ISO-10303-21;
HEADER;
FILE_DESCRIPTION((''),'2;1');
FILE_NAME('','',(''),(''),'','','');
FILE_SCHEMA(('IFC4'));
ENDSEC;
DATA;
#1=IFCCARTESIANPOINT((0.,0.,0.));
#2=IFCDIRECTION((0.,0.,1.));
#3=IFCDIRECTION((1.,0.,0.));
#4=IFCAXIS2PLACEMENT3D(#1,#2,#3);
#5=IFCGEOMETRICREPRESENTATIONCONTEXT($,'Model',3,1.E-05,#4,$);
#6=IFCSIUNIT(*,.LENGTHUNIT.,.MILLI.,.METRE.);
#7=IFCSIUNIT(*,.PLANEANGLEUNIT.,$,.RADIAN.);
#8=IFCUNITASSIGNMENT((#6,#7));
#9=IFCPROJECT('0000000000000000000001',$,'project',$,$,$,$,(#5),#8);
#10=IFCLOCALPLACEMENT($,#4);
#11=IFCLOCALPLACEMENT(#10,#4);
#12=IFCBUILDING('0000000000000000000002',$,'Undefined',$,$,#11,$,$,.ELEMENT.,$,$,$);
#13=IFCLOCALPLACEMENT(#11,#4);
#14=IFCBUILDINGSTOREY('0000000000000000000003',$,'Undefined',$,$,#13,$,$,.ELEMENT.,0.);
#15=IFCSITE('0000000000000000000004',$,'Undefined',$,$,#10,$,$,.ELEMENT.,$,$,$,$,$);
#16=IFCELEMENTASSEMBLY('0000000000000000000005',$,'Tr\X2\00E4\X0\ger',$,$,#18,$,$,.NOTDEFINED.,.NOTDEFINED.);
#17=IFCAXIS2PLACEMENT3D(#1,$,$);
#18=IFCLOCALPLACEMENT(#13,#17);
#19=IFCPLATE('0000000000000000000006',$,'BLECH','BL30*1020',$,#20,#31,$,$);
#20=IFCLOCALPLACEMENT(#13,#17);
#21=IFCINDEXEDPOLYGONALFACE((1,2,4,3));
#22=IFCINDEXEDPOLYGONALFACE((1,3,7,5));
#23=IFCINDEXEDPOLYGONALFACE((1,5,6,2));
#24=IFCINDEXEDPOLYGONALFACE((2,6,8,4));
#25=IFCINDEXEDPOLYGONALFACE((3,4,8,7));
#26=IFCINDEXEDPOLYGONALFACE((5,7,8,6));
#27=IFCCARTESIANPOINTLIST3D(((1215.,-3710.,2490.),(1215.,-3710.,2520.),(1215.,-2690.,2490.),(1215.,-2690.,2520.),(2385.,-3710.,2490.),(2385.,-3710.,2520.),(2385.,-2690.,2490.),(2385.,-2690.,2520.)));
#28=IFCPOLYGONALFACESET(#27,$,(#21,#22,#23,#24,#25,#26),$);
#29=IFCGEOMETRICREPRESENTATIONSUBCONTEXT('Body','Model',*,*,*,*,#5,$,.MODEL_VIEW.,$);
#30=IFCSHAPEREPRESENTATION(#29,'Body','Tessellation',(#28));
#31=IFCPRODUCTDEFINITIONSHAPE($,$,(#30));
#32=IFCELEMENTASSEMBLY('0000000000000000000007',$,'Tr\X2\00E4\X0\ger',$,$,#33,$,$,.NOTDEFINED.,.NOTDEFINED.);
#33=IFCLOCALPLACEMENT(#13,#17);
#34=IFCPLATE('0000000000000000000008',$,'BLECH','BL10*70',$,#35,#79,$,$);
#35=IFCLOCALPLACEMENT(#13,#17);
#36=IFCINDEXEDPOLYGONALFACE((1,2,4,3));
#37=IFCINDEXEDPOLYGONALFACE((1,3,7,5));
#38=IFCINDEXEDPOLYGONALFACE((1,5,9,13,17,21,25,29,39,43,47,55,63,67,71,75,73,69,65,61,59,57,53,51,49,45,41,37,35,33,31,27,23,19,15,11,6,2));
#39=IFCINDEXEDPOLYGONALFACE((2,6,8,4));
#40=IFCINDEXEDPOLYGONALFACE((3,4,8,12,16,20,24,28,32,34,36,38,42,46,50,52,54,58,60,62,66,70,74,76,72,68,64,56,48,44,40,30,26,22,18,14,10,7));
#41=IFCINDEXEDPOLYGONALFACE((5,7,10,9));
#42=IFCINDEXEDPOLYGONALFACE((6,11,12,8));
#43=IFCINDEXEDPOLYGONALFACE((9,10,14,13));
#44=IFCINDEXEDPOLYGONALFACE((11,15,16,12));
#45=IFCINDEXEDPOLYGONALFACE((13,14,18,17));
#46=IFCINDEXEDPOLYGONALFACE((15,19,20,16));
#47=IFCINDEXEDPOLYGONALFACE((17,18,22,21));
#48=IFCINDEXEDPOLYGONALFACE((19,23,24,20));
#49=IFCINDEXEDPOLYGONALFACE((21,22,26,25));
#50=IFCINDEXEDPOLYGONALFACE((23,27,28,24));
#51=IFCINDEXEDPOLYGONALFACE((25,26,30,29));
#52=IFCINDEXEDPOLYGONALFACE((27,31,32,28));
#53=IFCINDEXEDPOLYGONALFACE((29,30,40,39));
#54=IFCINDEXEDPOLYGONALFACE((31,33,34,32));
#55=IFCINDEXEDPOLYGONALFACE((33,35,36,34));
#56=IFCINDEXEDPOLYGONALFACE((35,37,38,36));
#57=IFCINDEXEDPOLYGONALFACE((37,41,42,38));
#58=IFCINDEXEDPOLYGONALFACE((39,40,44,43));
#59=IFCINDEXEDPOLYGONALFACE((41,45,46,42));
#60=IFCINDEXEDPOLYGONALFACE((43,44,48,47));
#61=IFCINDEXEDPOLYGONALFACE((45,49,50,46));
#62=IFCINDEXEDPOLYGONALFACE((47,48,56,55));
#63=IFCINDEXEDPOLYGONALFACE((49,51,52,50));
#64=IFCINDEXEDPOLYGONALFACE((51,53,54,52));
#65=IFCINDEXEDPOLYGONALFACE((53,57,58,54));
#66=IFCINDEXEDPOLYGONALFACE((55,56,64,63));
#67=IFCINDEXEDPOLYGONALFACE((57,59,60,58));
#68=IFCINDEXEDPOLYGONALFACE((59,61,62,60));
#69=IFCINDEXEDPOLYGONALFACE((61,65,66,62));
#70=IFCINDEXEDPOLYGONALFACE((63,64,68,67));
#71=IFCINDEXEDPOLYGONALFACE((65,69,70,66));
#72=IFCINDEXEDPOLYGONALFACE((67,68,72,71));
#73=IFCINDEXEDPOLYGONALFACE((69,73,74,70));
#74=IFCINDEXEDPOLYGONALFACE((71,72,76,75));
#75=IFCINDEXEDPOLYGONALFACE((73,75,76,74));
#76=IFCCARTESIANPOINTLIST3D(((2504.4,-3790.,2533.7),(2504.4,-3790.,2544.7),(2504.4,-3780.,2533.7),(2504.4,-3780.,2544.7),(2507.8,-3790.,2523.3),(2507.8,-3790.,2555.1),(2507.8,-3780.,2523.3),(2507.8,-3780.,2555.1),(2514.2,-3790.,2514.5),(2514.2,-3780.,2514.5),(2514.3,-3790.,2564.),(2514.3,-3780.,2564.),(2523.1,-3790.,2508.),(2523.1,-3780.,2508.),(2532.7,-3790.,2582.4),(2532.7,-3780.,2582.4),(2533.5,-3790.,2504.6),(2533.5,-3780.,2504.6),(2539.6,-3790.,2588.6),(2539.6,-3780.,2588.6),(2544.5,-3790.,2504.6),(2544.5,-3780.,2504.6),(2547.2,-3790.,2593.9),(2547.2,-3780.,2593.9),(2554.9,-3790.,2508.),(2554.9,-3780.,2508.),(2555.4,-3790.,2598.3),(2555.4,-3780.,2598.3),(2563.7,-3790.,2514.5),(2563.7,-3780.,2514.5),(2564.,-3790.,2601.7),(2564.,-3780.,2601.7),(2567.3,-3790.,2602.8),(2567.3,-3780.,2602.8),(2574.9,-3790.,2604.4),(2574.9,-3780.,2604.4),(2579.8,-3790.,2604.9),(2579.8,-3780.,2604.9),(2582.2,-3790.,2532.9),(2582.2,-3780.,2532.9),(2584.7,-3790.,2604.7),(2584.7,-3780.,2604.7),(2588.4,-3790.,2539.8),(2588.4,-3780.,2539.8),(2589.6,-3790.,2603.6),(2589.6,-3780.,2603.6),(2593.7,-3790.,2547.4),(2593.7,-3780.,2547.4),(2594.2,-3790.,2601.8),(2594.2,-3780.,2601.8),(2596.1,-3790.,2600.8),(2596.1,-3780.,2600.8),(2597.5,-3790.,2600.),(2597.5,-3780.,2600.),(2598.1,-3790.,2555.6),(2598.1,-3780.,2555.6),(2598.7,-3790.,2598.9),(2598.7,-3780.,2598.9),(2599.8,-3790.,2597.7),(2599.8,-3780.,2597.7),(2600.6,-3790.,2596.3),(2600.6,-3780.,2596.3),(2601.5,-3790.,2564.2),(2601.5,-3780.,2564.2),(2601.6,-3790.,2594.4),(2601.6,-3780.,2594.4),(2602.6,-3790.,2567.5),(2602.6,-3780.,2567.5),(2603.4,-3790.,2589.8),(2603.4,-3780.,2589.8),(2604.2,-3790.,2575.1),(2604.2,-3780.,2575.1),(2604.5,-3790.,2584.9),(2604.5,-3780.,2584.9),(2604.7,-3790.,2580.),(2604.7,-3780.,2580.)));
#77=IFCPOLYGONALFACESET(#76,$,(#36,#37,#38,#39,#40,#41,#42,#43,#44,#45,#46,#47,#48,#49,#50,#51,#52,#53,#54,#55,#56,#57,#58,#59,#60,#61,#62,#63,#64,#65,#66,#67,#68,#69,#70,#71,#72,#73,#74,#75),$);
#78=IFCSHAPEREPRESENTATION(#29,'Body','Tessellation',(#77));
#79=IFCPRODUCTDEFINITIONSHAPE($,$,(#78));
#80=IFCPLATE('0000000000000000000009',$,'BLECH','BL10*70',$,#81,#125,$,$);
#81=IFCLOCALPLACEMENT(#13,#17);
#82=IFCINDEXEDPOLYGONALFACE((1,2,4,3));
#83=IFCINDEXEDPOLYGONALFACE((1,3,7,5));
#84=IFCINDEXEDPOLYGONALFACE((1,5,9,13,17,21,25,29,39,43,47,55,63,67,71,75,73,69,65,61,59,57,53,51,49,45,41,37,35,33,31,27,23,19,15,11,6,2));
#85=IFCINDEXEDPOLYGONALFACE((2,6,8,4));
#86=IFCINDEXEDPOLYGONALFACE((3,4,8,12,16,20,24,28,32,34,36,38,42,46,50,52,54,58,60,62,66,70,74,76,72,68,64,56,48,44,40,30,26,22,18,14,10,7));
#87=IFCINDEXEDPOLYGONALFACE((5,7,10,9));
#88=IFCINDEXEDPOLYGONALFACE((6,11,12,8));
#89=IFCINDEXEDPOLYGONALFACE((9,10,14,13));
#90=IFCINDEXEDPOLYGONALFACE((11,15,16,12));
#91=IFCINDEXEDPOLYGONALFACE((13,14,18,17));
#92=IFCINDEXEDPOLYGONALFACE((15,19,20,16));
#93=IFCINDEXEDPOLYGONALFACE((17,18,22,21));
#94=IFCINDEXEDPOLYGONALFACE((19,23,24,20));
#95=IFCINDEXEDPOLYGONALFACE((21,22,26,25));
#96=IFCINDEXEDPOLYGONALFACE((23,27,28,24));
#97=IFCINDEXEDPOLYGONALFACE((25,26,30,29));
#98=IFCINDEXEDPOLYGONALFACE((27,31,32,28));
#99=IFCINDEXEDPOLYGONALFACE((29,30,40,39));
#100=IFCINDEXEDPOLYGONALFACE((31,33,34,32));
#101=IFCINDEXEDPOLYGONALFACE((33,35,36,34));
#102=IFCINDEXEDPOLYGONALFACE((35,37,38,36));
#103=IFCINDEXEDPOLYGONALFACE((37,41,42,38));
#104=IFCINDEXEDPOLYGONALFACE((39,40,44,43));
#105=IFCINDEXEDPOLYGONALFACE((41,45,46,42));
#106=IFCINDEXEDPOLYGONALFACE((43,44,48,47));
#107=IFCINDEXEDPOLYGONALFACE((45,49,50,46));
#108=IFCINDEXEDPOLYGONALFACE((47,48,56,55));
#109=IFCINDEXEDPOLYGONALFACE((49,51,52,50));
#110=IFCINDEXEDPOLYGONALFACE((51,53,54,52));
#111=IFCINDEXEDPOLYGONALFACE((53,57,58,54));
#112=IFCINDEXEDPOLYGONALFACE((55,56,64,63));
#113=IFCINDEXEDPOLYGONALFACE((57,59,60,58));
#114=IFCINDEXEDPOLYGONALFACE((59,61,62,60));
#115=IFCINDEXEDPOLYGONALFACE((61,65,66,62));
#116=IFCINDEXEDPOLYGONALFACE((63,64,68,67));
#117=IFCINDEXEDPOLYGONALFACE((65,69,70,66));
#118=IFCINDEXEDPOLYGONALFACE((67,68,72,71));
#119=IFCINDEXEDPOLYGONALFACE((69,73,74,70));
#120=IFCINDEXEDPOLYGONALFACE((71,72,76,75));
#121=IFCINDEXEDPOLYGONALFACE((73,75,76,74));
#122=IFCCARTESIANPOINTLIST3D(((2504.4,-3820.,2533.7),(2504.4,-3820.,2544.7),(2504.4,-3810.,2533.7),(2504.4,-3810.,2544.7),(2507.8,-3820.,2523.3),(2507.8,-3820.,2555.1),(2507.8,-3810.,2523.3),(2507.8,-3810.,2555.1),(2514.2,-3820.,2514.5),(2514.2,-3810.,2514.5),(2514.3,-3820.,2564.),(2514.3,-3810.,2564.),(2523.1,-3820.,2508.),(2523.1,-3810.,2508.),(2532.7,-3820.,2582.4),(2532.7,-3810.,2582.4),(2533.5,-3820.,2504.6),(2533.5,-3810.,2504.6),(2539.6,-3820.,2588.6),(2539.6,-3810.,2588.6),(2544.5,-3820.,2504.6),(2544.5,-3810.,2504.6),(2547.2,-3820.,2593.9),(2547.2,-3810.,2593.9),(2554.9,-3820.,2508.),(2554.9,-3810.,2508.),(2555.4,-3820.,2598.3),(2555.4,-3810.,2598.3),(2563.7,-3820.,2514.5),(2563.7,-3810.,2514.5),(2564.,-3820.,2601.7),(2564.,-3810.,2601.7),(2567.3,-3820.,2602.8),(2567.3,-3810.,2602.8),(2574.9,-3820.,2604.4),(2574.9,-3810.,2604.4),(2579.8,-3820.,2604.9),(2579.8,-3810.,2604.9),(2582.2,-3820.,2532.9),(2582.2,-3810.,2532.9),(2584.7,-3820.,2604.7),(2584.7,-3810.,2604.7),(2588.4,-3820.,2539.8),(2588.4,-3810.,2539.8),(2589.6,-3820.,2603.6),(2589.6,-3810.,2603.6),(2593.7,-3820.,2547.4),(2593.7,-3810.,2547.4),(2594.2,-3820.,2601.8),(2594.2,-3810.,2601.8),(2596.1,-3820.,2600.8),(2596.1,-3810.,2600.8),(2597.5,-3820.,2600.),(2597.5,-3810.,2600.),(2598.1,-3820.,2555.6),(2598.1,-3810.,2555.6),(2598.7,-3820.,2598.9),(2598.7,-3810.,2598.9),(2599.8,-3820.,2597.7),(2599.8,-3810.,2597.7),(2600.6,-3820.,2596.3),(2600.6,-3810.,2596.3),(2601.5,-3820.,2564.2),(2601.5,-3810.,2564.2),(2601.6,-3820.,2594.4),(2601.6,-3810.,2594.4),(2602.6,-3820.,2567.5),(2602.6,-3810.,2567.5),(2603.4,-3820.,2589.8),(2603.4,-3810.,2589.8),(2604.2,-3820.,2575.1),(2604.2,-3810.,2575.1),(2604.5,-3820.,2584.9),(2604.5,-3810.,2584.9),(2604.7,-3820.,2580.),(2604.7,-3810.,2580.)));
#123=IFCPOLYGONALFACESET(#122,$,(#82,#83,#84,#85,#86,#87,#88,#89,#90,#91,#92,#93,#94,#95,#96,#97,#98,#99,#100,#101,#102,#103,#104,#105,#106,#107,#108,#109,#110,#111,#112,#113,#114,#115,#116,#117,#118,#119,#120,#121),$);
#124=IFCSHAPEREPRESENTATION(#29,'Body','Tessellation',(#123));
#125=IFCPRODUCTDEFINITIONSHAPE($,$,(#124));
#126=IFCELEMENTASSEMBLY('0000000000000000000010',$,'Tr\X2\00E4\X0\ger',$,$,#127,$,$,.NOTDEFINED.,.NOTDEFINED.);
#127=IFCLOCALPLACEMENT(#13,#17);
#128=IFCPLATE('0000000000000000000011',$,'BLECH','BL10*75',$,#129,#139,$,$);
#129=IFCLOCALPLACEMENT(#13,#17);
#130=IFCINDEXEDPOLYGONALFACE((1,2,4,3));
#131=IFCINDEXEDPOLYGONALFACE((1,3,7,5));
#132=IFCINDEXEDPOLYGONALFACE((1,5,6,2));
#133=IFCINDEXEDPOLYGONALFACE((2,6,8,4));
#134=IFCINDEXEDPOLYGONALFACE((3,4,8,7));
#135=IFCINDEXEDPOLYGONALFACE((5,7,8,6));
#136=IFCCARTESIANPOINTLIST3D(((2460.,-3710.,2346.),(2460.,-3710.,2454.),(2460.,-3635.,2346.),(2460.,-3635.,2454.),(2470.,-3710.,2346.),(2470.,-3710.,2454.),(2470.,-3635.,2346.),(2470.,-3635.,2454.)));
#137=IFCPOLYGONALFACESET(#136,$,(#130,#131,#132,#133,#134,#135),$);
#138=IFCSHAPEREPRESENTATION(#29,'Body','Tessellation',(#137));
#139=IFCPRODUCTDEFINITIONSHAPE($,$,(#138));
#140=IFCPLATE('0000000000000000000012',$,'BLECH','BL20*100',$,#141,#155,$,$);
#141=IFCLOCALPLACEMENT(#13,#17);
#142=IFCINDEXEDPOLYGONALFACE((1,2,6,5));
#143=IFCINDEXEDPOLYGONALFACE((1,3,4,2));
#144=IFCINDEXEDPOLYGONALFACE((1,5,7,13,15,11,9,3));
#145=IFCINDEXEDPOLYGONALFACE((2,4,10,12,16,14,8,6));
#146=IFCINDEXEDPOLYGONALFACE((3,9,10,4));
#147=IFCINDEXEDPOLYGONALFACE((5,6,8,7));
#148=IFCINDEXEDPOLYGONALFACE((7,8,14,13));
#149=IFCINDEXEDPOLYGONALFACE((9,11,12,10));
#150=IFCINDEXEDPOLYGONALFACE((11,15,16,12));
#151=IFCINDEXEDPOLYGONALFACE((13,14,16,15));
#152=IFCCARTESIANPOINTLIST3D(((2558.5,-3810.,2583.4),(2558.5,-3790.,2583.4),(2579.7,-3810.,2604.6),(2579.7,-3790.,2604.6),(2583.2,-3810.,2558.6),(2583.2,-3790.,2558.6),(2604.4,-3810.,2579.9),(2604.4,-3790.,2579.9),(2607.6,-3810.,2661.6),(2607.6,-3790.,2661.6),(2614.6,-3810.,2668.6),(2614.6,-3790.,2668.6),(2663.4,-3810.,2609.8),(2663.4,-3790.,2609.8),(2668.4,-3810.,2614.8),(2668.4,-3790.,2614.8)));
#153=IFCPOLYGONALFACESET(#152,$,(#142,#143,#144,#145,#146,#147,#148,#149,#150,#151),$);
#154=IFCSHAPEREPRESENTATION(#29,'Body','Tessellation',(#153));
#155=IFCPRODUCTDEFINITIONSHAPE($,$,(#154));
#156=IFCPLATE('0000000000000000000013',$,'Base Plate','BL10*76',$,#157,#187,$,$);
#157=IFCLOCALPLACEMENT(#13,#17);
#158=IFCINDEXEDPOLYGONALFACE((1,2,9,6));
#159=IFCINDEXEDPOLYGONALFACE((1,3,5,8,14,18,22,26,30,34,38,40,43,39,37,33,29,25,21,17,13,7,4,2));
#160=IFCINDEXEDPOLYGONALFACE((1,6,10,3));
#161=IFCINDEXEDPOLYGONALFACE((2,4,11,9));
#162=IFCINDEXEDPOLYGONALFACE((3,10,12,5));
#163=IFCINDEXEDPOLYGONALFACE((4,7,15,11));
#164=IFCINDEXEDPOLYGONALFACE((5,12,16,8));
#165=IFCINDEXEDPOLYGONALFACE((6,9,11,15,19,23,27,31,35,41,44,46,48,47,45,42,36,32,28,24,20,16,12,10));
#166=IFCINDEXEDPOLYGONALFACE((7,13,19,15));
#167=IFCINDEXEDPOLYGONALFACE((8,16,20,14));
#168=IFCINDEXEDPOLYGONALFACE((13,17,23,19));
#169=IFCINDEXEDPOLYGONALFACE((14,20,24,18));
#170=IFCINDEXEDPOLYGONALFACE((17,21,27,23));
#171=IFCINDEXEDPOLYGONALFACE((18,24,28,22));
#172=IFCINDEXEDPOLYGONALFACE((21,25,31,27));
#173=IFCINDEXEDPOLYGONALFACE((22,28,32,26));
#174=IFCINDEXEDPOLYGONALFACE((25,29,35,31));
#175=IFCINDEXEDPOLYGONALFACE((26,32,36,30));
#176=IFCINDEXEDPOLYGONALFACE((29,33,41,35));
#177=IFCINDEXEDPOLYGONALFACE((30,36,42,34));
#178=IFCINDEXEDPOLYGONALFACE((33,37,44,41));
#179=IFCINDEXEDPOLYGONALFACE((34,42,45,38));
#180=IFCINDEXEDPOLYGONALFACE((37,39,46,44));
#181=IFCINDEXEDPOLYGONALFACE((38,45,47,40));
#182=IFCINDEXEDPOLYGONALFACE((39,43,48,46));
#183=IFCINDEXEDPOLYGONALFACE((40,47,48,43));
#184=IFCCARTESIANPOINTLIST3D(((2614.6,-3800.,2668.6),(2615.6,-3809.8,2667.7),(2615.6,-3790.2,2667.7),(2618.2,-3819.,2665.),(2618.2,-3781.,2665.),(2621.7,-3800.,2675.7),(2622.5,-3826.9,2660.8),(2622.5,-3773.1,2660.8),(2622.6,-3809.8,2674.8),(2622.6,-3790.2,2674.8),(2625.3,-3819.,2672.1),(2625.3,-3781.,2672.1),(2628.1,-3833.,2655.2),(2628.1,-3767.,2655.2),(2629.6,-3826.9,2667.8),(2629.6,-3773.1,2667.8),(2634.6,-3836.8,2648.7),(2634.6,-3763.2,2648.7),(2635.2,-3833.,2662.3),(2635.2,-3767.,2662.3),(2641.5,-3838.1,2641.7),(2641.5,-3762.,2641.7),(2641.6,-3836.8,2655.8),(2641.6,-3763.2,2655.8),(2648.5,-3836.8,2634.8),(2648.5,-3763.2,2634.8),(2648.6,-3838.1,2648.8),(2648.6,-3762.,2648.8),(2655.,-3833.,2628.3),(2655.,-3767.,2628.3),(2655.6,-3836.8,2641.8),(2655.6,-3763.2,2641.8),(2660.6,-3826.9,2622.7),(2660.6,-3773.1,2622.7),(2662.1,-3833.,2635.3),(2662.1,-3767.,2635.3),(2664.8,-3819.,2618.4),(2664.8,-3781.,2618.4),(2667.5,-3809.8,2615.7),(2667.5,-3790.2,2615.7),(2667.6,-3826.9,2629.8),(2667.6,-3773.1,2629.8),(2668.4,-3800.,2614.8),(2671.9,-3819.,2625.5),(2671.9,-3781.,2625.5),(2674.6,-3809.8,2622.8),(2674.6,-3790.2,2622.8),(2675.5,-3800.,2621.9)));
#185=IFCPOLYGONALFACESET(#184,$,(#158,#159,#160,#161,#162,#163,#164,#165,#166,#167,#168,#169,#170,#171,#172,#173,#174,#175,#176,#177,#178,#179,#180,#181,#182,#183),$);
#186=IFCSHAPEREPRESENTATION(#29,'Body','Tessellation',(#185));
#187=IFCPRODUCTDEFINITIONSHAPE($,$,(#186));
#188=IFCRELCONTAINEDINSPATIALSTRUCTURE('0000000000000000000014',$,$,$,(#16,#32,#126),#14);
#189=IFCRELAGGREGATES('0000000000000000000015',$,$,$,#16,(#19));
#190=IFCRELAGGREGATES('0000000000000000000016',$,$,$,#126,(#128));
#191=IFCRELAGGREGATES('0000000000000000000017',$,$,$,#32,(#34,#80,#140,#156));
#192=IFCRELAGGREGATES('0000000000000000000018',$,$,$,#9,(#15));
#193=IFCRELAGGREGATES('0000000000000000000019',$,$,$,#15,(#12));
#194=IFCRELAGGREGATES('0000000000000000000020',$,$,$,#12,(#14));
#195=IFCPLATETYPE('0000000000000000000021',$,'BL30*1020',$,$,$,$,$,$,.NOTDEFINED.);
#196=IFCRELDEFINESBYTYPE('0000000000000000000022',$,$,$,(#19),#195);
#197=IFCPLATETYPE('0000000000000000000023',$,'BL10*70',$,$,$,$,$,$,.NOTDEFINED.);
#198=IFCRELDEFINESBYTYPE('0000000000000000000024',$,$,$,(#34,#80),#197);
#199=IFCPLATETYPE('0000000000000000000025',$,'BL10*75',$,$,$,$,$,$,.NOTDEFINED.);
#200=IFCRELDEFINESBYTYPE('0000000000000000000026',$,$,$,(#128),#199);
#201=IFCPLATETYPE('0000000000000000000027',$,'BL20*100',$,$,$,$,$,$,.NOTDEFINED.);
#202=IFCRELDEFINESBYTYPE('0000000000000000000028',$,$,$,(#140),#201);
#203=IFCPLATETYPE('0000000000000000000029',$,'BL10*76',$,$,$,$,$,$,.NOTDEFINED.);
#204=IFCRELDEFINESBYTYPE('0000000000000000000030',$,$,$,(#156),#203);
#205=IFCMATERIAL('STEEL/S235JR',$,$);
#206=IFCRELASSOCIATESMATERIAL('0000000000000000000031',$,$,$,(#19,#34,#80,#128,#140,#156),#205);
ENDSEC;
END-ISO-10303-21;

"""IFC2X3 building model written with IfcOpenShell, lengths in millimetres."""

from ifc_helpers import new_model, si_unit, frame, frame_2d, origin_with_axes, place, context, subcontext, project, spatial, polyline, circle_curve, parameter, trimmed, segment, composite_curve, outline, extrude, material, type_object, element, aggregate, save


model = new_model("IFC2X3")

# Units and contexts
model_context = context("Model", 3, precision=1e-05, world=origin_with_axes())
body_context = subcontext(model_context, "Body", "Model", "MODEL_VIEW")
ifc_project = project(units=[si_unit("LENGTHUNIT", "METRE", prefix="MILLI"), si_unit("PLANEANGLEUNIT", "RADIAN")], contexts=[model_context])

# Site, building, storey
site_placement = place(None, origin_with_axes())
site = spatial("IfcSite", under=ifc_project, at=site_placement, Name="Undefined", CompositionType="ELEMENT")
building_placement = place(site_placement, origin_with_axes())
building = spatial("IfcBuilding", under=site, at=building_placement, Name="Undefined", CompositionType="ELEMENT")
storey_placement = place(building_placement, origin_with_axes())
storey = spatial("IfcBuildingStorey", under=building, at=storey_placement, Name="Undefined", CompositionType="ELEMENT", Elevation=0.0)

# Shared definitions
ifc_material = material(Name="STEEL/S235JR")

# Element assembly
assembly_1_placement = place(storey_placement, origin_with_axes())
assembly_1 = element("IfcElementAssembly", 1, at=assembly_1_placement, inside=storey, Name="Träger", AssemblyPlace="NOTDEFINED", PredefinedType="NOTDEFINED")

# Plate
plate_type_1 = type_object("IfcPlateType", Name="BL30*1020", PredefinedType="NOTDEFINED")
plate_1_placement = place(assembly_1_placement, frame((2385.0, -2690.0, 2505.0), z_axis=(0.0, 0.0, 1.0), x_axis=(-1.0, 0.0, 0.0)))
plate_1 = element("IfcPlate", 2, at=plate_1_placement, type_object=plate_type_1, material=ifc_material, Name="BLECH", Description="BL30*1020", context=body_context, shape_type="SweptSolid", body=[
    extrude(outline(polyline([(0.0, 0.0), (1170.0, 0.0), (1170.0, 1020.0), (0.0, 1020.0), (0.0, 0.0)])), frame((0.0, 0.0, -15.0), z_axis=(0.0, 0.0, 1.0), x_axis=(1.0, 0.0, 0.0)), (0.0, 0.0, 1.0), 30.0),
])
aggregate(assembly_1, [plate_1])

# Element assembly, plates
assembly_2_placement = place(storey_placement, origin_with_axes())
assembly_2 = element("IfcElementAssembly", 3, at=assembly_2_placement, inside=storey, Name="Träger", AssemblyPlace="NOTDEFINED", PredefinedType="NOTDEFINED")
plate_type_2 = type_object("IfcPlateType", Name="BL10*70", PredefinedType="NOTDEFINED")
plate_2_placement = place(assembly_2_placement, frame((2546.1, -3785.0, 2595.8), z_axis=(0.0, 1.0, 0.0), x_axis=(0.948699, 0.0, 0.316182)))
plate_2 = element("IfcPlate", 4, at=plate_2_placement, type_object=plate_type_2, material=ifc_material, Name="BLECH", Description="BL10*70", context=body_context, shape_type="SweptSolid", body=[
    extrude(outline(polyline([(-16.9, 8.4), (-8.4, 4.8), (0.5, 2.1), (9.6, 0.5), (18.9, 0.0), (22.4, 0.0), (30.0, 1.0), (34.9, 2.0), (39.5, 3.8), (43.7, 6.3), (47.5, 9.5), (49.1, 11.1), (50.1, 12.3), (50.9, 13.7), (51.5, 15.1), (51.9, 16.7), (52.2, 18.9), (52.5, 23.8), (52.0, 28.7), (50.6, 33.5), (48.6, 38.0), (44.7, 44.7), (42.6, 47.5), (36.6, 54.6), (29.9, 60.9), (22.4, 66.4), (14.4, 71.0), (-9.0, 82.7), (-19.4, 86.0), (-30.3, 86.0), (-40.7, 82.5), (-49.5, 76.0), (-55.9, 67.1), (-55.9, 67.1), (-59.2, 56.6), (-59.1, 45.7), (-55.7, 35.3), (-49.2, 26.5), (-40.3, 20.1), (-16.9, 8.4)])), frame((0.0, 0.0, -5.0), z_axis=(0.0, 0.0, 1.0), x_axis=(1.0, 0.0, 0.0)), (0.0, 0.0, 1.0), 10.0),
])
plate_3_placement = place(assembly_2_placement, frame((2546.1, -3815.0, 2595.8), z_axis=(0.0, 1.0, 0.0), x_axis=(0.948699, 0.0, 0.316182)))
plate_3 = element("IfcPlate", 5, at=plate_3_placement, type_object=plate_type_2, material=ifc_material, Name="BLECH", Description="BL10*70", context=body_context, shape_type="SweptSolid", body=[
    extrude(outline(polyline([(-16.9, 8.4), (-8.4, 4.8), (0.5, 2.1), (9.6, 0.5), (18.9, 0.0), (22.4, 0.0), (30.0, 1.0), (34.9, 2.0), (39.5, 3.8), (43.7, 6.3), (47.5, 9.5), (49.1, 11.1), (50.1, 12.3), (50.9, 13.7), (51.5, 15.1), (51.9, 16.7), (52.2, 18.9), (52.5, 23.8), (52.0, 28.7), (50.6, 33.5), (48.6, 38.0), (44.7, 44.7), (42.6, 47.5), (36.6, 54.6), (29.9, 60.9), (22.4, 66.4), (14.4, 71.0), (-9.0, 82.7), (-19.4, 86.0), (-30.3, 86.0), (-40.7, 82.5), (-49.5, 76.0), (-55.9, 67.1), (-55.9, 67.1), (-59.2, 56.6), (-59.1, 45.7), (-55.7, 35.3), (-49.2, 26.5), (-40.3, 20.1), (-16.9, 8.4)])), frame((0.0, 0.0, -5.0), z_axis=(0.0, 0.0, 1.0), x_axis=(1.0, 0.0, 0.0)), (0.0, 0.0, 1.0), 10.0),
])

# Element assembly, plate
assembly_3_placement = place(storey_placement, origin_with_axes())
assembly_3 = element("IfcElementAssembly", 6, at=assembly_3_placement, inside=storey, Name="Träger", AssemblyPlace="NOTDEFINED", PredefinedType="NOTDEFINED")
plate_type_3 = type_object("IfcPlateType", Name="BL10*75", PredefinedType="NOTDEFINED")
plate_4_placement = place(assembly_3_placement, frame((2465.0, -3710.0, 2454.0), z_axis=(-1.0, 0.0, 0.0), x_axis=(0.0, 1.0, 0.0)))
plate_4 = element("IfcPlate", 7, at=plate_4_placement, type_object=plate_type_3, material=ifc_material, Name="BLECH", Description="BL10*75", context=body_context, shape_type="SweptSolid", body=[
    extrude(outline(polyline([(0.0, 0.0), (75.0, 0.0), (75.0, 108.0), (0.0, 108.0), (0.0, 0.0)])), frame((0.0, 0.0, -5.0), z_axis=(0.0, 0.0, 1.0), x_axis=(1.0, 0.0, 0.0)), (0.0, 0.0, 1.0), 10.0),
])
aggregate(assembly_3, [plate_4])

# Plates
plate_type_4 = type_object("IfcPlateType", Name="BL20*100", PredefinedType="NOTDEFINED")
plate_5_placement = place(assembly_2_placement, frame((2607.6, -3800.0, 2661.6), z_axis=(0.0, 1.0, 0.0), x_axis=(0.707141, 0.0, 0.707072)))
plate_5 = element("IfcPlate", 8, at=plate_5_placement, type_object=plate_type_4, material=ifc_material, Name="BLECH", Description="BL20*100", context=body_context, shape_type="SweptSolid", body=[
    extrude(outline(polyline([(0.0, 0.0), (10.0, 0.0), (10.0, 76.1), (2.9, 76.1), (-60.0, 55.5), (-90.0, 55.5), (-90.0, 20.5), (-60.0, 20.5), (0.0, 0.0)])), frame((0.0, 0.0, -10.0), z_axis=(0.0, 0.0, 1.0), x_axis=(1.0, 0.0, 0.0)), (0.0, 0.0, 1.0), 20.0),
])
plate_type_5 = type_object("IfcPlateType", Name="BL10*76", PredefinedType="NOTDEFINED")
plate_6_placement = place(assembly_2_placement, frame((2672.0, -3838.1, 2618.4), z_axis=(-0.707141, 0.0, -0.707072), x_axis=(-0.707072, 0.0, 0.707141)))
plate_6 = element("IfcPlate", 9, at=plate_6_placement, type_object=plate_type_5, material=ifc_material, Name="Base Plate", Description="BL10*76", context=body_context, shape_type="SweptSolid", body=[
    extrude(outline(composite_curve([segment(trimmed(circle_curve(frame_2d((38.0, 38.0), x_axis=(-1.0, 0.0)), 38.0), [parameter(0.0)], [parameter(1.570796)], True, "PARAMETER"), True, "CONTINUOUS"), segment(trimmed(circle_curve(frame_2d((38.0, 38.0), x_axis=(0.0, -1.0)), 38.0), [parameter(0.0)], [parameter(1.570796)], True, "PARAMETER"), True, "CONTINUOUS"), segment(trimmed(circle_curve(frame_2d((38.0, 38.0), x_axis=(1.0, 0.0)), 38.0), [parameter(0.0)], [parameter(1.570796)], True, "PARAMETER"), True, "CONTINUOUS"), segment(trimmed(circle_curve(frame_2d((38.0, 38.0), x_axis=(0.0, 1.0)), 38.0), [parameter(0.0)], [parameter(1.570796)], True, "PARAMETER"), True, "CONTINUOUS")], self_intersect=True)), frame((0.0, 0.0, -5.0), z_axis=(0.0, 0.0, 1.0), x_axis=(1.0, 0.0, 0.0)), (0.0, 0.0, 1.0), 10.0),
])
aggregate(assembly_2, [plate_2, plate_3, plate_5, plate_6])

save(model, "model.ifc")
